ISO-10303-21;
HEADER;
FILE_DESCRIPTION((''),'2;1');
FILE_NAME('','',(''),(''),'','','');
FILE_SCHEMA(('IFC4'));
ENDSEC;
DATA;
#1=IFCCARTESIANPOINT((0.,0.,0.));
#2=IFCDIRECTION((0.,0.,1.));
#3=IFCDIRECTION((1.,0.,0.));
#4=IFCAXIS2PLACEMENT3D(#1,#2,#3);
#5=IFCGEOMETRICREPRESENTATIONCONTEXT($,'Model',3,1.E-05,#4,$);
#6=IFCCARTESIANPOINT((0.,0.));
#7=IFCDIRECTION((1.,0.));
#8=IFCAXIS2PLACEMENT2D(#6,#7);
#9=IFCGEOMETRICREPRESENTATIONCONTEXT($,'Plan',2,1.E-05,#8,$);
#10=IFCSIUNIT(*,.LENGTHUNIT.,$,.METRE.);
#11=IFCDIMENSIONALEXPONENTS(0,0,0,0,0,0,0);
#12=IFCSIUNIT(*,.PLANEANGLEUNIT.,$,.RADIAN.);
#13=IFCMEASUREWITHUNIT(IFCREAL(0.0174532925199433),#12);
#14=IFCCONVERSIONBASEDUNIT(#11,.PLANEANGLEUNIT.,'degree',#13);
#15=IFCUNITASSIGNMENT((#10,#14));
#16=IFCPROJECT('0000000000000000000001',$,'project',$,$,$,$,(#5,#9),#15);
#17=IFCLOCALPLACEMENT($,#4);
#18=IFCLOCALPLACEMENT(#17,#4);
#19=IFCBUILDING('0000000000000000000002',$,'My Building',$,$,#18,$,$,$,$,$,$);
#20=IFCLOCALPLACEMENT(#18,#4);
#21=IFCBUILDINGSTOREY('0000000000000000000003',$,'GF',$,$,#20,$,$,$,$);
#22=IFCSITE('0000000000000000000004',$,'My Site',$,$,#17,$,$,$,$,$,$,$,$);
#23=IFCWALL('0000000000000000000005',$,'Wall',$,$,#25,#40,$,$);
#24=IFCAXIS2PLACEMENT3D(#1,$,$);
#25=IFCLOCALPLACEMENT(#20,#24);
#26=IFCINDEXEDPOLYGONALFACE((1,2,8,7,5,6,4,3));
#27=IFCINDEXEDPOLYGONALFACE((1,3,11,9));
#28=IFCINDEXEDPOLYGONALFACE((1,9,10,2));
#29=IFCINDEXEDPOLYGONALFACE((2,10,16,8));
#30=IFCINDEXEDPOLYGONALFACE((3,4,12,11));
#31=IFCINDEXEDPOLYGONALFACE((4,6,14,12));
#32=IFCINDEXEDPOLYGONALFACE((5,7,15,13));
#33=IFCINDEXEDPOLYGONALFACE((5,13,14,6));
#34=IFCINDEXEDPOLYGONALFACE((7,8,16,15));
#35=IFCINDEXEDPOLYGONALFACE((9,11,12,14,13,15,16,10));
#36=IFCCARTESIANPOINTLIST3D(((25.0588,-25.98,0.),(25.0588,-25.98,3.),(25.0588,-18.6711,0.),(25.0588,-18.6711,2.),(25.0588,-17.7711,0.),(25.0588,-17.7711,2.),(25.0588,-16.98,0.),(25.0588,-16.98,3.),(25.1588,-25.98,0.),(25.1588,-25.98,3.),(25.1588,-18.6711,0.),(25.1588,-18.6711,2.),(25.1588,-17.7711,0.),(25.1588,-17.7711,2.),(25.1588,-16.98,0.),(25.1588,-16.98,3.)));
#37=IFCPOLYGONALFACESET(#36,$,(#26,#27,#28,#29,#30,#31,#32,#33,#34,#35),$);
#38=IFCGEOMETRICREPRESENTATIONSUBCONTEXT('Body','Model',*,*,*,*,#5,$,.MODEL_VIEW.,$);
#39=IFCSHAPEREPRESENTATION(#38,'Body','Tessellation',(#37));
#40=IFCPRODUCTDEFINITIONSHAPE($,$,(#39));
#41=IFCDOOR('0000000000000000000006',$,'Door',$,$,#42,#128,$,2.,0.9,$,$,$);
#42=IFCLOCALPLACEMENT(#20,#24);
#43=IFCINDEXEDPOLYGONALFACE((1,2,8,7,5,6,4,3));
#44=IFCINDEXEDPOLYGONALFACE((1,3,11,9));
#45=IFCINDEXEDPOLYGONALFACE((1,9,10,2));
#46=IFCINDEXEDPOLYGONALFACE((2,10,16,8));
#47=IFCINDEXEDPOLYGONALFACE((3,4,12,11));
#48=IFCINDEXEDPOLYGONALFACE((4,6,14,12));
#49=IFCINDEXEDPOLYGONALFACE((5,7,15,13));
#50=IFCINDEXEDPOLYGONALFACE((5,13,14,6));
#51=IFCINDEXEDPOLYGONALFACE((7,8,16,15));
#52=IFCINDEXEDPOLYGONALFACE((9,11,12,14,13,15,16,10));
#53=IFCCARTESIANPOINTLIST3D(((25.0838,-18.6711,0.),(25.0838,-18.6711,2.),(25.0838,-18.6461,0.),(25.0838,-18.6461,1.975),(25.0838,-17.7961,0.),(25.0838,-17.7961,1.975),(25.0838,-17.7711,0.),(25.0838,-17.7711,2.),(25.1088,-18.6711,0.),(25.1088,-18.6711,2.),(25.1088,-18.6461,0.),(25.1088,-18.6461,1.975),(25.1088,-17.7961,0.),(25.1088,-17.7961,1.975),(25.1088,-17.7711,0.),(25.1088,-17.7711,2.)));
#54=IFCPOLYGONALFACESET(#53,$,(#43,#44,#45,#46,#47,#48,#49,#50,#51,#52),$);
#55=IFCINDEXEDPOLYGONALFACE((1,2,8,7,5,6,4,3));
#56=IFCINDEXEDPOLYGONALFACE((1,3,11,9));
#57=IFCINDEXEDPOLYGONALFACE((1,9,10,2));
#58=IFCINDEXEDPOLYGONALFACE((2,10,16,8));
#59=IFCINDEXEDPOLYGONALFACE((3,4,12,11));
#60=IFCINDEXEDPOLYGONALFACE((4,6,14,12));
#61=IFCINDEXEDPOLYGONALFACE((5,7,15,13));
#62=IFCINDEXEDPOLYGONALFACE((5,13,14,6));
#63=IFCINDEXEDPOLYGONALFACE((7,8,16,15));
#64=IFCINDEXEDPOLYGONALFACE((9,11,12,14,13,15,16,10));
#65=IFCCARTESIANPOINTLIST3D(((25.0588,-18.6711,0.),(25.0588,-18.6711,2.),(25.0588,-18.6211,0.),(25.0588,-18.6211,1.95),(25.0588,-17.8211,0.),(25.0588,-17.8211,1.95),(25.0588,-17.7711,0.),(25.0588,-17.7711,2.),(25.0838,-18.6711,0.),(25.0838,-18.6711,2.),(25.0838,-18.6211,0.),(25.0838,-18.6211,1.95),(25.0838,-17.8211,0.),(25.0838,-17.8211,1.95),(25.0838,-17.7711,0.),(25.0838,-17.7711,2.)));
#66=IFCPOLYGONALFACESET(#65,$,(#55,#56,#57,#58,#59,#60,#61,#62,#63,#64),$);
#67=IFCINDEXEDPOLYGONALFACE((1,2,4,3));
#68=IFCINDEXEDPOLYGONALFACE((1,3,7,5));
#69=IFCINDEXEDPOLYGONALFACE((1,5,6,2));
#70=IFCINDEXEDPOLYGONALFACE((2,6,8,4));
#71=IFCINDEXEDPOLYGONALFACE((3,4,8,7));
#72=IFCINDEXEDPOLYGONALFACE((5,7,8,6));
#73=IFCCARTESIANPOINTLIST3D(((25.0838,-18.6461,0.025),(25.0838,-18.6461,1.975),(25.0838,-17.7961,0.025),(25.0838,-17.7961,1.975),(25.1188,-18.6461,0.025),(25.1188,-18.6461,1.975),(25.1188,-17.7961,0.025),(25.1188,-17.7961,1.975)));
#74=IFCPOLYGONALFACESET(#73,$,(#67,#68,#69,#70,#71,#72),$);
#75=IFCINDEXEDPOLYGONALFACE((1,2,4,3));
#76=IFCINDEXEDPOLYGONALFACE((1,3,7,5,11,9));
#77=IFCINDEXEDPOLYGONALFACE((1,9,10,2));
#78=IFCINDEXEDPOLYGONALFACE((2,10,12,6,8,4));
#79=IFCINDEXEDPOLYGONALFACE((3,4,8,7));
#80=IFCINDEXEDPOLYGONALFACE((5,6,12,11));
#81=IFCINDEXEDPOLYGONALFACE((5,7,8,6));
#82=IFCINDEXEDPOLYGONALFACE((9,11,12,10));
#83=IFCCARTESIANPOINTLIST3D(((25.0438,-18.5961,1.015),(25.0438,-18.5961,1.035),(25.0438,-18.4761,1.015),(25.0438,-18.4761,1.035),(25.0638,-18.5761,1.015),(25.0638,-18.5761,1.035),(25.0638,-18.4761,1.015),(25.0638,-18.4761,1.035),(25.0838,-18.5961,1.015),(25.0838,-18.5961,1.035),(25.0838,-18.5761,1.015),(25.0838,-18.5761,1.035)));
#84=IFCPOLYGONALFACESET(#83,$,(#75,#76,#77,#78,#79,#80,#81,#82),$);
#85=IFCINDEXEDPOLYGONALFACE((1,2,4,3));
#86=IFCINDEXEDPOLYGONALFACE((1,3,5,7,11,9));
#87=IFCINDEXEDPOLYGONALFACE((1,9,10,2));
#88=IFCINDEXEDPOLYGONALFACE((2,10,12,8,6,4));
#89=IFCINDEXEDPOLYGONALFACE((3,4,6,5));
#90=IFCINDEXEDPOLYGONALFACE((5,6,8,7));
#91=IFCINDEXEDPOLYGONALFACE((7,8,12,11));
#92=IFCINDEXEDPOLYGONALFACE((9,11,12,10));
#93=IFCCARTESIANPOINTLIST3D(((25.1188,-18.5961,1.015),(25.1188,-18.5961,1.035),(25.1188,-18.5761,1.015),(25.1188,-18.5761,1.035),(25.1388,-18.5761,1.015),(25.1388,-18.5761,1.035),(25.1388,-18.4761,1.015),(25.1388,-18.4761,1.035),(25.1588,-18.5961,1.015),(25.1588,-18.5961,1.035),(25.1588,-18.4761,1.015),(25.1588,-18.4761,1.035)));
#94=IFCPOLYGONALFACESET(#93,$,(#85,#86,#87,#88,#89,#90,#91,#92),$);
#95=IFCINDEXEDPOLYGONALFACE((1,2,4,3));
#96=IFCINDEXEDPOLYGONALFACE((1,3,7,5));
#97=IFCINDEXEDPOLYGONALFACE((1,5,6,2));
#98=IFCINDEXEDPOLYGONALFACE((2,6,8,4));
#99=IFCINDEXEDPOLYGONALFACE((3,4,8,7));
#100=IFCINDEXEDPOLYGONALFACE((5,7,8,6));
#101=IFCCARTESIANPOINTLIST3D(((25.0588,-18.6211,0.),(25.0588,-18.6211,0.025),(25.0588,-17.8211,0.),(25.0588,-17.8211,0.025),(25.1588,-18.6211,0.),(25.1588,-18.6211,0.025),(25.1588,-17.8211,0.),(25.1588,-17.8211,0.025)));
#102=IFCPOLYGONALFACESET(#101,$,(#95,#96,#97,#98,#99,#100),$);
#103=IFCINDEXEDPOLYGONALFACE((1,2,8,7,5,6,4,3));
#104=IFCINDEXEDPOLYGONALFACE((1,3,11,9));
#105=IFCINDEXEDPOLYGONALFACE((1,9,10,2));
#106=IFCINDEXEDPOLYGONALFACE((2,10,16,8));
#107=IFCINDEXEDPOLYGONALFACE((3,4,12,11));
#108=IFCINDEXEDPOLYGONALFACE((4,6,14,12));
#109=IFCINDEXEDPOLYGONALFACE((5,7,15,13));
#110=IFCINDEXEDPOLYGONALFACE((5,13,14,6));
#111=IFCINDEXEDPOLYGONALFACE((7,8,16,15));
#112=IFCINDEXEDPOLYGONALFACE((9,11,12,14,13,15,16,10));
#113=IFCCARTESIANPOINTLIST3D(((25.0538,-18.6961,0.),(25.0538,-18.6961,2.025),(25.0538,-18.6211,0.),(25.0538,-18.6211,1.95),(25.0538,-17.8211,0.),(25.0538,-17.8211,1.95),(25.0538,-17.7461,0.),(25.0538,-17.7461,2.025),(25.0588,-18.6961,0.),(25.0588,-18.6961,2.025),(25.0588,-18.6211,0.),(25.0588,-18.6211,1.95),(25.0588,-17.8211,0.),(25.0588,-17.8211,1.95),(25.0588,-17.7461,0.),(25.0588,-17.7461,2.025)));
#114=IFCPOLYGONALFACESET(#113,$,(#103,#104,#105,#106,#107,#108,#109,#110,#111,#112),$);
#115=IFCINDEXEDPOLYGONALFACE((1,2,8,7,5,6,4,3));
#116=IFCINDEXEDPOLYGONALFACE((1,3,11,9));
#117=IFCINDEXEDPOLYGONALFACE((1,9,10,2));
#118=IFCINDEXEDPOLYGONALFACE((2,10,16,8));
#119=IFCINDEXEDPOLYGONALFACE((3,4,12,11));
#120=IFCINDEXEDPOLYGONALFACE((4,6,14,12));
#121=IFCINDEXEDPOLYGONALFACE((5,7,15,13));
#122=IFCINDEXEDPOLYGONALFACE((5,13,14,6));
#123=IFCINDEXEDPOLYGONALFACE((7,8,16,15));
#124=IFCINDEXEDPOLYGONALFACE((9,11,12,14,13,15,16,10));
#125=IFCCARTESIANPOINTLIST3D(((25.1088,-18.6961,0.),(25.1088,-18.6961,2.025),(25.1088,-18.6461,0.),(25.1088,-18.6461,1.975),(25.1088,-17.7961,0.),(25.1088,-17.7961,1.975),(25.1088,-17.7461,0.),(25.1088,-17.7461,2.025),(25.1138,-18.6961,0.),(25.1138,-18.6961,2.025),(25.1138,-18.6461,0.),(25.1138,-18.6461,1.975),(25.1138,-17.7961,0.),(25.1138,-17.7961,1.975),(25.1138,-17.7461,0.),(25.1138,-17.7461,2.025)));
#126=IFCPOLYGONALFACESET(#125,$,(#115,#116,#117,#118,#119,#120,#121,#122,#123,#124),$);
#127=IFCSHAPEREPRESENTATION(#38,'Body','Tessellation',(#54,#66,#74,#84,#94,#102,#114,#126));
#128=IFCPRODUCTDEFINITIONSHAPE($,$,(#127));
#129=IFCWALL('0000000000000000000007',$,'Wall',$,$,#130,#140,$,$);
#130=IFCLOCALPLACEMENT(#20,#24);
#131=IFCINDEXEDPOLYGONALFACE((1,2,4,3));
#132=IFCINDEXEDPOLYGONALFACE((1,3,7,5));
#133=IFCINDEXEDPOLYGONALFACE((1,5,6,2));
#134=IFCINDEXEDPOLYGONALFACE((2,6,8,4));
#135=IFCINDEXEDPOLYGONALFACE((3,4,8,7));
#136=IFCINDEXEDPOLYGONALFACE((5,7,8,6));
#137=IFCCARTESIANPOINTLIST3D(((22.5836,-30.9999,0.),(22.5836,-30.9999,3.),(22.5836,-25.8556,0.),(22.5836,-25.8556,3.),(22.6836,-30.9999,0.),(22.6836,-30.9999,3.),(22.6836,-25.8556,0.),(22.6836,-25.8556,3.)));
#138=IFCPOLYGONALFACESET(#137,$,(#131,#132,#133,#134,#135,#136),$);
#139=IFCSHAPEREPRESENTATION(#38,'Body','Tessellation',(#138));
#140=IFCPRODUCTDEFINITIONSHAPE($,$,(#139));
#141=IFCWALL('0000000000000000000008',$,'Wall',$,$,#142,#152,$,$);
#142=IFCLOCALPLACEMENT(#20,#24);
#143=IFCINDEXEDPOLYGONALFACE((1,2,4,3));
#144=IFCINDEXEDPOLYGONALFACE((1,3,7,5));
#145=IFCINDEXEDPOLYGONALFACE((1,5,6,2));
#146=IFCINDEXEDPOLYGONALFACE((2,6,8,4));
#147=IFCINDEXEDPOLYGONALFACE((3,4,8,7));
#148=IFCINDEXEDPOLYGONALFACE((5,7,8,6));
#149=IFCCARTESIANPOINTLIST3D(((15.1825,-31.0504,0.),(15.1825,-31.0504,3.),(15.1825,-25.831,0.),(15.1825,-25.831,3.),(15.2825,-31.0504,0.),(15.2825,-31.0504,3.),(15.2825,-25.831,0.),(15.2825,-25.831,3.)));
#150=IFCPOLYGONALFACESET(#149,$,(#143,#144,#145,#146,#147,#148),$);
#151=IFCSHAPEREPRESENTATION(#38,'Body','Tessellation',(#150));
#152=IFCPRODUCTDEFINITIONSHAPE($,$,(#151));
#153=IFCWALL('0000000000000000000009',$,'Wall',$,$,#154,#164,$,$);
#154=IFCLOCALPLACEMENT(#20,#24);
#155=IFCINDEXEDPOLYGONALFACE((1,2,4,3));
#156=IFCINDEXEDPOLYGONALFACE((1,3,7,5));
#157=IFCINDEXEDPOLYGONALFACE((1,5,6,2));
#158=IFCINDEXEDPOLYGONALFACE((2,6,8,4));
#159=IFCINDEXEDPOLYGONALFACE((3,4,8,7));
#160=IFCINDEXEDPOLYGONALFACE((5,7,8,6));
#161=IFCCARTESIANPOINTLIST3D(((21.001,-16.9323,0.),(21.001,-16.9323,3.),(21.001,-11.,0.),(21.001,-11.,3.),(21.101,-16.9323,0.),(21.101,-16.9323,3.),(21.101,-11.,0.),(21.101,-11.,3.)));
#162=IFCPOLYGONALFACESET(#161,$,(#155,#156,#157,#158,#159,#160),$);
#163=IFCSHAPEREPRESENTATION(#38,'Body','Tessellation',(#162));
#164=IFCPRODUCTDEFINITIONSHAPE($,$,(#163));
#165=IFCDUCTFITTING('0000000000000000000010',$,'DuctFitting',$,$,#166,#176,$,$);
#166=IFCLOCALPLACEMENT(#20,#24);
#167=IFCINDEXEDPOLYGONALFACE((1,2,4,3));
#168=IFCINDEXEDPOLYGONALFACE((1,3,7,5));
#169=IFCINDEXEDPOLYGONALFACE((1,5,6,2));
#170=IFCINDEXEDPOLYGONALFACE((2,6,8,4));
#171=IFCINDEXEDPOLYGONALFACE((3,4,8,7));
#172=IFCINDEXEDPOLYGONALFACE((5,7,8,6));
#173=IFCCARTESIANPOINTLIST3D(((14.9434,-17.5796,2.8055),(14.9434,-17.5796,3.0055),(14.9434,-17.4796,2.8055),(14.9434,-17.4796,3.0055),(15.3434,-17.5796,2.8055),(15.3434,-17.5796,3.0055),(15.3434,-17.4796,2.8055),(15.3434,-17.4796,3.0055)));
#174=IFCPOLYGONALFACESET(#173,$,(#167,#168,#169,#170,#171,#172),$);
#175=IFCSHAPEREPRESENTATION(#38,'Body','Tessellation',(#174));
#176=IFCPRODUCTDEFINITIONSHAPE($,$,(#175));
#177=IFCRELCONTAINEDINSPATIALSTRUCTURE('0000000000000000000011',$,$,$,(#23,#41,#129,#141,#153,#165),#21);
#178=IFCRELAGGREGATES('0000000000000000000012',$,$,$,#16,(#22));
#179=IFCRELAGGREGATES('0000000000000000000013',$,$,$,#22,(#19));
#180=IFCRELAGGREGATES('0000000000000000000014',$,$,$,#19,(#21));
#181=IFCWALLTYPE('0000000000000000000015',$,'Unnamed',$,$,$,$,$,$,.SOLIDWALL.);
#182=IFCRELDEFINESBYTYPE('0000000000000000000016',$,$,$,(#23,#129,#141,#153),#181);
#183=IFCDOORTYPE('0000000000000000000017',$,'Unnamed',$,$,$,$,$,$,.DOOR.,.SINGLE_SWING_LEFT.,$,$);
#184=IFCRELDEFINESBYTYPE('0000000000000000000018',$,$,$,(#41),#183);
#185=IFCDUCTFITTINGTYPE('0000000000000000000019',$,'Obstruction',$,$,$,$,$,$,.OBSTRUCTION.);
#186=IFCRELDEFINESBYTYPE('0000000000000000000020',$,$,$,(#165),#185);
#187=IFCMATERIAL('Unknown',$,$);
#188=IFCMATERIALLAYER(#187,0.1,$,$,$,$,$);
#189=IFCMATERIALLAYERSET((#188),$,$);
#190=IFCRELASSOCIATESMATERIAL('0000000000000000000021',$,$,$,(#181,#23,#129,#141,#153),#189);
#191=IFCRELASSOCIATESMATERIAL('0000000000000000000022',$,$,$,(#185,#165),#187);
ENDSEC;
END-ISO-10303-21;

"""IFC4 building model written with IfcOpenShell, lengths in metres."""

from ifc_helpers import new_model, entity, si_unit, converted_unit, frame, origin_with_axes, origin_2d_with_axis, place, context, subcontext, project, spatial, line, indexed_curve, rectangle, outline, extrude, shape, source, transform, mapped, material, layer, layer_set, layer_usage, material_profile, profile_set, profile_usage, type_object, type_shapes, element, fill, save


model = new_model("IFC4")

# Units and contexts
model_context = context("Model", 3, precision=1e-05, world=origin_with_axes())
plan_context = context("Plan", 2, precision=1e-05, world=origin_2d_with_axis())
body_context_1 = subcontext(model_context, "Body", "Model", "MODEL_VIEW")
body_context_2 = subcontext(plan_context, "Body", "Plan", "PLAN_VIEW")
ifc_project = project(units=[si_unit("LENGTHUNIT", "METRE"), converted_unit("PLANEANGLEUNIT", "degree", entity("IfcReal", 0.0174532925199433), si_unit("PLANEANGLEUNIT", "RADIAN"), dimensions=[0, 0, 0, 0, 0, 0, 0])], contexts=[model_context, plan_context])

# Site, building, storey
site_placement = place(None, origin_with_axes())
site = spatial("IfcSite", under=ifc_project, at=site_placement, Name="My Site")
building_placement = place(site_placement, origin_with_axes())
building = spatial("IfcBuilding", under=site, at=building_placement, Name="My Building")
storey_placement = place(building_placement, origin_with_axes())
storey = spatial("IfcBuildingStorey", under=building, at=storey_placement, Name="GF")

# Shared definitions
ifc_material = material(Name="Unknown")
ifc_layer = layer(ifc_material, 0.1)
ifc_layer_set = layer_set([ifc_layer])
wall_type = type_object("IfcWallType", Name="Unnamed", PredefinedType="SOLIDWALL", material=ifc_layer_set)

# Shared definitions
shared_shape_1 = source(origin_with_axes(), body_context_1, "Body", "SweptSolid", [
    extrude(outline(indexed_curve([(0.0, 0.0), (0.9, 0.0), (0.9, 2.0), (0.0, 2.0)], segments=[line(1, 2, 3, 4, 1)])), frame((0.0, -0.6, 0.0), z_axis=(0.0, -1.0, 0.0), x_axis=(1.0, 0.0, 0.0)), (0.0, 0.0, -1.0), 1.2),
])
door_type = type_object("IfcDoorType", Name="Unnamed", OperationType="SINGLE_SWING_LEFT", PredefinedType="DOOR")
shared_shape_2 = source(origin_with_axes(), body_context_1, "Body", "SweptSolid", [
    extrude(outline(indexed_curve([(0.0, 0.0), (0.0, 2.0), (0.9, 2.0), (0.9, 0.0), (0.875, 0.0), (0.875, 1.975), (0.025, 1.975), (0.025, 0.0)], segments=[line(1, 2, 3, 4, 5, 6, 7, 8, 1)])), frame((0.0, 0.025, 0.0), z_axis=(0.0, -1.0, 0.0), x_axis=(1.0, 0.0, 0.0)), (0.0, 0.0, -1.0), 0.025),
    extrude(outline(indexed_curve([(0.0, 0.0), (0.0, 2.0), (0.9, 2.0), (0.9, 0.0), (0.85, 0.0), (0.85, 1.95), (0.05, 1.95), (0.05, 0.0)], segments=[line(1, 2, 3, 4, 5, 6, 7, 8, 1)])), frame((0.0, 0.0, 0.0), z_axis=(0.0, -1.0, 0.0), x_axis=(1.0, 0.0, 0.0)), (0.0, 0.0, -1.0), 0.025),
    extrude(outline(indexed_curve([(0.0, 0.0), (0.85, 0.0), (0.85, 0.035), (0.0, 0.035)], segments=[line(1, 2, 3, 4, 1)])), frame((0.025, 0.025, 0.025), z_axis=(0.0, 0.0, 1.0), x_axis=(1.0, 0.0, 0.0)), (0.0, 0.0, 1.0), 1.95),
    extrude(outline(indexed_curve([(0.0, 0.0), (0.0, -0.04), (-0.12, -0.04), (-0.12, -0.02), (-0.02, -0.02), (-0.02, 0.0)], segments=[line(1, 2, 3, 4, 5, 6, 1)])), frame((0.825, 0.025, 1.015), z_axis=(0.0, 0.0, 1.0), x_axis=(1.0, 0.0, 0.0)), (0.0, 0.0, 1.0), 0.02),
    extrude(outline(indexed_curve([(0.0, 0.0), (0.0, 0.04), (-0.12, 0.04), (-0.12, 0.02), (-0.02, 0.02), (-0.02, 0.0)], segments=[line(1, 2, 3, 4, 5, 6, 1)])), frame((0.825, 0.06, 1.015), z_axis=(0.0, 0.0, 1.0), x_axis=(1.0, 0.0, 0.0)), (0.0, 0.0, 1.0), 0.02),
    extrude(outline(indexed_curve([(0.0, 0.0), (0.8, 0.0), (0.8, 0.1), (0.0, 0.1)], segments=[line(1, 2, 3, 4, 1)])), frame((0.05, 0.0, 0.0), z_axis=(0.0, 0.0, 1.0), x_axis=(1.0, 0.0, 0.0)), (0.0, 0.0, 1.0), 0.025),
    extrude(outline(indexed_curve([(0.0, 0.0), (0.0, 2.025), (0.95, 2.025), (0.95, 0.0), (0.875, 0.0), (0.875, 1.95), (0.075, 1.95), (0.075, 0.0)], segments=[line(1, 2, 3, 4, 5, 6, 7, 8, 1)])), frame((-0.025, -0.005, 0.0), z_axis=(0.0, -1.0, 0.0), x_axis=(1.0, 0.0, 0.0)), (0.0, 0.0, -1.0), 0.005),
    extrude(outline(indexed_curve([(0.0, 0.0), (0.0, 2.025), (0.95, 2.025), (0.95, 0.0), (0.9, 0.0), (0.9, 1.975), (0.05, 1.975), (0.05, 0.0)], segments=[line(1, 2, 3, 4, 5, 6, 7, 8, 1)])), frame((-0.025, 0.05, 0.0), z_axis=(0.0, -1.0, 0.0), x_axis=(1.0, 0.0, 0.0)), (0.0, 0.0, -1.0), 0.005),
])
shared_shape_3 = source(origin_with_axes(), body_context_2, "Body", "Curve2D", [
    entity("IfcIndexedPolyCurve", entity("IfcCartesianPointList2D", [[0.0, 0.0], [0.0, 0.05], [0.025, 0.05], [0.025, 0.025], [0.05, 0.025], [0.05, 0.0]]), [entity("IfcLineIndex", [1, 2, 3, 4, 5, 6, 1])]),
    entity("IfcIndexedPolyCurve", entity("IfcCartesianPointList2D", [[0.9, 0.0], [0.9, 0.05], [0.875, 0.05], [0.875, 0.025], [0.85, 0.025], [0.85, 0.0]]), [entity("IfcLineIndex", [1, 2, 3, 4, 5, 6, 1])]),
    entity("IfcTrimmedCurve", entity("IfcEllipse", entity("IfcAxis2Placement2D", entity("IfcCartesianPoint", [0.06, 0.05]), entity("IfcDirection", [1.0, 0.0])), 0.815, 0.85), [entity("IfcCartesianPoint", [0.875, 0.05])], [entity("IfcCartesianPoint", [0.06, 0.9])], True, "CARTESIAN"),
    entity("IfcIndexedPolyCurve", entity("IfcCartesianPointList2D", [[0.025, 0.05], [0.06, 0.05], [0.06, 0.9], [0.025, 0.9]]), [entity("IfcLineIndex", [1, 2, 3, 4, 1])]),
])
type_shapes(door_type, [shared_shape_2, shared_shape_3])

# Wall, opening, door
ifc_layer_usage_1 = layer_usage(ifc_layer_set, "AXIS2", "POSITIVE", 0.0)
wall_1_placement = place(storey_placement, frame((25.0588, -16.98, 0.0), z_axis=(0.0, 0.0, 1.0), x_axis=(0.0, -1.0, 0.0)))
wall_1 = element("IfcWall", 1, at=wall_1_placement, inside=storey, type_object=wall_type, material=ifc_layer_usage_1, Name="Wall", context=body_context_1, shape_type="SweptSolid", body=[
    extrude(outline(indexed_curve([(0.0, 0.0), (0.0, 0.1), (9.0, 0.1), (9.0, 0.0)], segments=[line(1, 2, 3, 4, 1)])), origin_with_axes(), (0.0, 0.0, 1.0), 3.0),
])
opening_1_placement = place(wall_1_placement, frame((0.7911, 0.0, 0.0), z_axis=(0.0, 0.0, 1.0), x_axis=(1.0, 0.0, 0.0)))
opening_1 = element("IfcOpeningElement", 2, at=opening_1_placement, cuts=wall_1, PredefinedType="OPENING", context=body_context_1, shape_type="MappedRepresentation", body=[
    mapped(shared_shape_1, transform((0.0, 0.0, 0.0), x_axis=(1.0, 0.0, 0.0), y_axis=(0.0, 1.0, 0.0), z_axis=(0.0, 0.0, 1.0), scale=1.0)),
])
door_1_placement = place(opening_1_placement, frame((0.0, 0.0, 0.0), z_axis=(0.0, 0.0, 1.0), x_axis=(1.0, 0.0, 0.0)))
door_1 = element("IfcDoor", 3, at=door_1_placement, inside=storey, type_object=door_type, Name="Door", OverallHeight=2.0, OverallWidth=0.9, shapes=[
    shape(body_context_1, "Body", "MappedRepresentation", [mapped(shared_shape_2, transform((0.0, 0.0, 0.0), x_axis=(1.0, 0.0, 0.0), y_axis=(0.0, 1.0, 0.0), z_axis=(0.0, 0.0, 1.0), scale=1.0))]),
    shape(body_context_2, "Body", "MappedRepresentation", [mapped(shared_shape_3, transform((0.0, 0.0, 0.0), x_axis=(1.0, 0.0, 0.0), y_axis=(0.0, 1.0, 0.0), z_axis=(0.0, 0.0, 1.0), scale=1.0))]),
])
fill(opening_1, door_1)

# Walls
ifc_layer_usage_2 = layer_usage(ifc_layer_set, "AXIS2", "POSITIVE", 0.0)
wall_2_placement = place(storey_placement, frame((22.5836, -25.8556, 0.0), z_axis=(0.0, 0.0, 1.0), x_axis=(0.0, -1.0, 0.0)))
element("IfcWall", 4, at=wall_2_placement, inside=storey, type_object=wall_type, material=ifc_layer_usage_2, Name="Wall", context=body_context_1, shape_type="SweptSolid", body=[
    extrude(outline(indexed_curve([(0.0, 0.0), (0.0, 0.1), (5.1443, 0.1), (5.1443, 0.0)], segments=[line(1, 2, 3, 4, 1)])), origin_with_axes(), (0.0, 0.0, 1.0), 3.0),
])
ifc_layer_usage_3 = layer_usage(ifc_layer_set, "AXIS2", "POSITIVE", 0.0)
wall_3_placement = place(storey_placement, frame((15.1825, -25.831, 0.0), z_axis=(0.0, 0.0, 1.0), x_axis=(0.0, -1.0, 0.0)))
element("IfcWall", 5, at=wall_3_placement, inside=storey, type_object=wall_type, material=ifc_layer_usage_3, Name="Wall", context=body_context_1, shape_type="SweptSolid", body=[
    extrude(outline(indexed_curve([(0.0, 0.0), (0.0, 0.1), (5.2194, 0.1), (5.2194, 0.0)], segments=[line(1, 2, 3, 4, 1)])), origin_with_axes(), (0.0, 0.0, 1.0), 3.0),
])
ifc_layer_usage_4 = layer_usage(ifc_layer_set, "AXIS2", "POSITIVE", 0.0)
wall_4_placement = place(storey_placement, frame((21.101, -16.9323, 0.0), z_axis=(0.0, 0.0, 1.0), x_axis=(0.0, 1.0, 0.0)))
element("IfcWall", 6, at=wall_4_placement, inside=storey, type_object=wall_type, material=ifc_layer_usage_4, Name="Wall", context=body_context_1, shape_type="SweptSolid", body=[
    extrude(outline(indexed_curve([(0.0, 0.0), (0.0, 0.1), (5.9323, 0.1), (5.9323, 0.0)], segments=[line(1, 2, 3, 4, 1)])), origin_with_axes(), (0.0, 0.0, 1.0), 3.0),
])

# Duct fitting
ifc_material_profile = material_profile(ifc_material, rectangle(XDim=0.4, YDim=0.2))
ifc_profile_set = profile_set([ifc_material_profile])
ifc_profile_usage_1 = profile_usage(ifc_profile_set, cardinal=5)
duct_fitting_type = type_object("IfcDuctFittingType", Name="Obstruction", PredefinedType="OBSTRUCTION", material=ifc_profile_set)
duct_fitting_1_placement = place(storey_placement, frame((15.1434, -17.5796, 2.9055), z_axis=(0.0, 1.0, 0.0), x_axis=(-1.0, 0.0, 0.0)))
element("IfcDuctFitting", 7, at=duct_fitting_1_placement, inside=storey, type_object=duct_fitting_type, material=ifc_profile_usage_1, Name="DuctFitting", context=body_context_1, shape_type="SweptSolid", body=[
    extrude(rectangle(XDim=0.4, YDim=0.2), origin_with_axes(), (0.0, 0.0, 1.0), 0.1),
])

save(model, "model.ifc")
